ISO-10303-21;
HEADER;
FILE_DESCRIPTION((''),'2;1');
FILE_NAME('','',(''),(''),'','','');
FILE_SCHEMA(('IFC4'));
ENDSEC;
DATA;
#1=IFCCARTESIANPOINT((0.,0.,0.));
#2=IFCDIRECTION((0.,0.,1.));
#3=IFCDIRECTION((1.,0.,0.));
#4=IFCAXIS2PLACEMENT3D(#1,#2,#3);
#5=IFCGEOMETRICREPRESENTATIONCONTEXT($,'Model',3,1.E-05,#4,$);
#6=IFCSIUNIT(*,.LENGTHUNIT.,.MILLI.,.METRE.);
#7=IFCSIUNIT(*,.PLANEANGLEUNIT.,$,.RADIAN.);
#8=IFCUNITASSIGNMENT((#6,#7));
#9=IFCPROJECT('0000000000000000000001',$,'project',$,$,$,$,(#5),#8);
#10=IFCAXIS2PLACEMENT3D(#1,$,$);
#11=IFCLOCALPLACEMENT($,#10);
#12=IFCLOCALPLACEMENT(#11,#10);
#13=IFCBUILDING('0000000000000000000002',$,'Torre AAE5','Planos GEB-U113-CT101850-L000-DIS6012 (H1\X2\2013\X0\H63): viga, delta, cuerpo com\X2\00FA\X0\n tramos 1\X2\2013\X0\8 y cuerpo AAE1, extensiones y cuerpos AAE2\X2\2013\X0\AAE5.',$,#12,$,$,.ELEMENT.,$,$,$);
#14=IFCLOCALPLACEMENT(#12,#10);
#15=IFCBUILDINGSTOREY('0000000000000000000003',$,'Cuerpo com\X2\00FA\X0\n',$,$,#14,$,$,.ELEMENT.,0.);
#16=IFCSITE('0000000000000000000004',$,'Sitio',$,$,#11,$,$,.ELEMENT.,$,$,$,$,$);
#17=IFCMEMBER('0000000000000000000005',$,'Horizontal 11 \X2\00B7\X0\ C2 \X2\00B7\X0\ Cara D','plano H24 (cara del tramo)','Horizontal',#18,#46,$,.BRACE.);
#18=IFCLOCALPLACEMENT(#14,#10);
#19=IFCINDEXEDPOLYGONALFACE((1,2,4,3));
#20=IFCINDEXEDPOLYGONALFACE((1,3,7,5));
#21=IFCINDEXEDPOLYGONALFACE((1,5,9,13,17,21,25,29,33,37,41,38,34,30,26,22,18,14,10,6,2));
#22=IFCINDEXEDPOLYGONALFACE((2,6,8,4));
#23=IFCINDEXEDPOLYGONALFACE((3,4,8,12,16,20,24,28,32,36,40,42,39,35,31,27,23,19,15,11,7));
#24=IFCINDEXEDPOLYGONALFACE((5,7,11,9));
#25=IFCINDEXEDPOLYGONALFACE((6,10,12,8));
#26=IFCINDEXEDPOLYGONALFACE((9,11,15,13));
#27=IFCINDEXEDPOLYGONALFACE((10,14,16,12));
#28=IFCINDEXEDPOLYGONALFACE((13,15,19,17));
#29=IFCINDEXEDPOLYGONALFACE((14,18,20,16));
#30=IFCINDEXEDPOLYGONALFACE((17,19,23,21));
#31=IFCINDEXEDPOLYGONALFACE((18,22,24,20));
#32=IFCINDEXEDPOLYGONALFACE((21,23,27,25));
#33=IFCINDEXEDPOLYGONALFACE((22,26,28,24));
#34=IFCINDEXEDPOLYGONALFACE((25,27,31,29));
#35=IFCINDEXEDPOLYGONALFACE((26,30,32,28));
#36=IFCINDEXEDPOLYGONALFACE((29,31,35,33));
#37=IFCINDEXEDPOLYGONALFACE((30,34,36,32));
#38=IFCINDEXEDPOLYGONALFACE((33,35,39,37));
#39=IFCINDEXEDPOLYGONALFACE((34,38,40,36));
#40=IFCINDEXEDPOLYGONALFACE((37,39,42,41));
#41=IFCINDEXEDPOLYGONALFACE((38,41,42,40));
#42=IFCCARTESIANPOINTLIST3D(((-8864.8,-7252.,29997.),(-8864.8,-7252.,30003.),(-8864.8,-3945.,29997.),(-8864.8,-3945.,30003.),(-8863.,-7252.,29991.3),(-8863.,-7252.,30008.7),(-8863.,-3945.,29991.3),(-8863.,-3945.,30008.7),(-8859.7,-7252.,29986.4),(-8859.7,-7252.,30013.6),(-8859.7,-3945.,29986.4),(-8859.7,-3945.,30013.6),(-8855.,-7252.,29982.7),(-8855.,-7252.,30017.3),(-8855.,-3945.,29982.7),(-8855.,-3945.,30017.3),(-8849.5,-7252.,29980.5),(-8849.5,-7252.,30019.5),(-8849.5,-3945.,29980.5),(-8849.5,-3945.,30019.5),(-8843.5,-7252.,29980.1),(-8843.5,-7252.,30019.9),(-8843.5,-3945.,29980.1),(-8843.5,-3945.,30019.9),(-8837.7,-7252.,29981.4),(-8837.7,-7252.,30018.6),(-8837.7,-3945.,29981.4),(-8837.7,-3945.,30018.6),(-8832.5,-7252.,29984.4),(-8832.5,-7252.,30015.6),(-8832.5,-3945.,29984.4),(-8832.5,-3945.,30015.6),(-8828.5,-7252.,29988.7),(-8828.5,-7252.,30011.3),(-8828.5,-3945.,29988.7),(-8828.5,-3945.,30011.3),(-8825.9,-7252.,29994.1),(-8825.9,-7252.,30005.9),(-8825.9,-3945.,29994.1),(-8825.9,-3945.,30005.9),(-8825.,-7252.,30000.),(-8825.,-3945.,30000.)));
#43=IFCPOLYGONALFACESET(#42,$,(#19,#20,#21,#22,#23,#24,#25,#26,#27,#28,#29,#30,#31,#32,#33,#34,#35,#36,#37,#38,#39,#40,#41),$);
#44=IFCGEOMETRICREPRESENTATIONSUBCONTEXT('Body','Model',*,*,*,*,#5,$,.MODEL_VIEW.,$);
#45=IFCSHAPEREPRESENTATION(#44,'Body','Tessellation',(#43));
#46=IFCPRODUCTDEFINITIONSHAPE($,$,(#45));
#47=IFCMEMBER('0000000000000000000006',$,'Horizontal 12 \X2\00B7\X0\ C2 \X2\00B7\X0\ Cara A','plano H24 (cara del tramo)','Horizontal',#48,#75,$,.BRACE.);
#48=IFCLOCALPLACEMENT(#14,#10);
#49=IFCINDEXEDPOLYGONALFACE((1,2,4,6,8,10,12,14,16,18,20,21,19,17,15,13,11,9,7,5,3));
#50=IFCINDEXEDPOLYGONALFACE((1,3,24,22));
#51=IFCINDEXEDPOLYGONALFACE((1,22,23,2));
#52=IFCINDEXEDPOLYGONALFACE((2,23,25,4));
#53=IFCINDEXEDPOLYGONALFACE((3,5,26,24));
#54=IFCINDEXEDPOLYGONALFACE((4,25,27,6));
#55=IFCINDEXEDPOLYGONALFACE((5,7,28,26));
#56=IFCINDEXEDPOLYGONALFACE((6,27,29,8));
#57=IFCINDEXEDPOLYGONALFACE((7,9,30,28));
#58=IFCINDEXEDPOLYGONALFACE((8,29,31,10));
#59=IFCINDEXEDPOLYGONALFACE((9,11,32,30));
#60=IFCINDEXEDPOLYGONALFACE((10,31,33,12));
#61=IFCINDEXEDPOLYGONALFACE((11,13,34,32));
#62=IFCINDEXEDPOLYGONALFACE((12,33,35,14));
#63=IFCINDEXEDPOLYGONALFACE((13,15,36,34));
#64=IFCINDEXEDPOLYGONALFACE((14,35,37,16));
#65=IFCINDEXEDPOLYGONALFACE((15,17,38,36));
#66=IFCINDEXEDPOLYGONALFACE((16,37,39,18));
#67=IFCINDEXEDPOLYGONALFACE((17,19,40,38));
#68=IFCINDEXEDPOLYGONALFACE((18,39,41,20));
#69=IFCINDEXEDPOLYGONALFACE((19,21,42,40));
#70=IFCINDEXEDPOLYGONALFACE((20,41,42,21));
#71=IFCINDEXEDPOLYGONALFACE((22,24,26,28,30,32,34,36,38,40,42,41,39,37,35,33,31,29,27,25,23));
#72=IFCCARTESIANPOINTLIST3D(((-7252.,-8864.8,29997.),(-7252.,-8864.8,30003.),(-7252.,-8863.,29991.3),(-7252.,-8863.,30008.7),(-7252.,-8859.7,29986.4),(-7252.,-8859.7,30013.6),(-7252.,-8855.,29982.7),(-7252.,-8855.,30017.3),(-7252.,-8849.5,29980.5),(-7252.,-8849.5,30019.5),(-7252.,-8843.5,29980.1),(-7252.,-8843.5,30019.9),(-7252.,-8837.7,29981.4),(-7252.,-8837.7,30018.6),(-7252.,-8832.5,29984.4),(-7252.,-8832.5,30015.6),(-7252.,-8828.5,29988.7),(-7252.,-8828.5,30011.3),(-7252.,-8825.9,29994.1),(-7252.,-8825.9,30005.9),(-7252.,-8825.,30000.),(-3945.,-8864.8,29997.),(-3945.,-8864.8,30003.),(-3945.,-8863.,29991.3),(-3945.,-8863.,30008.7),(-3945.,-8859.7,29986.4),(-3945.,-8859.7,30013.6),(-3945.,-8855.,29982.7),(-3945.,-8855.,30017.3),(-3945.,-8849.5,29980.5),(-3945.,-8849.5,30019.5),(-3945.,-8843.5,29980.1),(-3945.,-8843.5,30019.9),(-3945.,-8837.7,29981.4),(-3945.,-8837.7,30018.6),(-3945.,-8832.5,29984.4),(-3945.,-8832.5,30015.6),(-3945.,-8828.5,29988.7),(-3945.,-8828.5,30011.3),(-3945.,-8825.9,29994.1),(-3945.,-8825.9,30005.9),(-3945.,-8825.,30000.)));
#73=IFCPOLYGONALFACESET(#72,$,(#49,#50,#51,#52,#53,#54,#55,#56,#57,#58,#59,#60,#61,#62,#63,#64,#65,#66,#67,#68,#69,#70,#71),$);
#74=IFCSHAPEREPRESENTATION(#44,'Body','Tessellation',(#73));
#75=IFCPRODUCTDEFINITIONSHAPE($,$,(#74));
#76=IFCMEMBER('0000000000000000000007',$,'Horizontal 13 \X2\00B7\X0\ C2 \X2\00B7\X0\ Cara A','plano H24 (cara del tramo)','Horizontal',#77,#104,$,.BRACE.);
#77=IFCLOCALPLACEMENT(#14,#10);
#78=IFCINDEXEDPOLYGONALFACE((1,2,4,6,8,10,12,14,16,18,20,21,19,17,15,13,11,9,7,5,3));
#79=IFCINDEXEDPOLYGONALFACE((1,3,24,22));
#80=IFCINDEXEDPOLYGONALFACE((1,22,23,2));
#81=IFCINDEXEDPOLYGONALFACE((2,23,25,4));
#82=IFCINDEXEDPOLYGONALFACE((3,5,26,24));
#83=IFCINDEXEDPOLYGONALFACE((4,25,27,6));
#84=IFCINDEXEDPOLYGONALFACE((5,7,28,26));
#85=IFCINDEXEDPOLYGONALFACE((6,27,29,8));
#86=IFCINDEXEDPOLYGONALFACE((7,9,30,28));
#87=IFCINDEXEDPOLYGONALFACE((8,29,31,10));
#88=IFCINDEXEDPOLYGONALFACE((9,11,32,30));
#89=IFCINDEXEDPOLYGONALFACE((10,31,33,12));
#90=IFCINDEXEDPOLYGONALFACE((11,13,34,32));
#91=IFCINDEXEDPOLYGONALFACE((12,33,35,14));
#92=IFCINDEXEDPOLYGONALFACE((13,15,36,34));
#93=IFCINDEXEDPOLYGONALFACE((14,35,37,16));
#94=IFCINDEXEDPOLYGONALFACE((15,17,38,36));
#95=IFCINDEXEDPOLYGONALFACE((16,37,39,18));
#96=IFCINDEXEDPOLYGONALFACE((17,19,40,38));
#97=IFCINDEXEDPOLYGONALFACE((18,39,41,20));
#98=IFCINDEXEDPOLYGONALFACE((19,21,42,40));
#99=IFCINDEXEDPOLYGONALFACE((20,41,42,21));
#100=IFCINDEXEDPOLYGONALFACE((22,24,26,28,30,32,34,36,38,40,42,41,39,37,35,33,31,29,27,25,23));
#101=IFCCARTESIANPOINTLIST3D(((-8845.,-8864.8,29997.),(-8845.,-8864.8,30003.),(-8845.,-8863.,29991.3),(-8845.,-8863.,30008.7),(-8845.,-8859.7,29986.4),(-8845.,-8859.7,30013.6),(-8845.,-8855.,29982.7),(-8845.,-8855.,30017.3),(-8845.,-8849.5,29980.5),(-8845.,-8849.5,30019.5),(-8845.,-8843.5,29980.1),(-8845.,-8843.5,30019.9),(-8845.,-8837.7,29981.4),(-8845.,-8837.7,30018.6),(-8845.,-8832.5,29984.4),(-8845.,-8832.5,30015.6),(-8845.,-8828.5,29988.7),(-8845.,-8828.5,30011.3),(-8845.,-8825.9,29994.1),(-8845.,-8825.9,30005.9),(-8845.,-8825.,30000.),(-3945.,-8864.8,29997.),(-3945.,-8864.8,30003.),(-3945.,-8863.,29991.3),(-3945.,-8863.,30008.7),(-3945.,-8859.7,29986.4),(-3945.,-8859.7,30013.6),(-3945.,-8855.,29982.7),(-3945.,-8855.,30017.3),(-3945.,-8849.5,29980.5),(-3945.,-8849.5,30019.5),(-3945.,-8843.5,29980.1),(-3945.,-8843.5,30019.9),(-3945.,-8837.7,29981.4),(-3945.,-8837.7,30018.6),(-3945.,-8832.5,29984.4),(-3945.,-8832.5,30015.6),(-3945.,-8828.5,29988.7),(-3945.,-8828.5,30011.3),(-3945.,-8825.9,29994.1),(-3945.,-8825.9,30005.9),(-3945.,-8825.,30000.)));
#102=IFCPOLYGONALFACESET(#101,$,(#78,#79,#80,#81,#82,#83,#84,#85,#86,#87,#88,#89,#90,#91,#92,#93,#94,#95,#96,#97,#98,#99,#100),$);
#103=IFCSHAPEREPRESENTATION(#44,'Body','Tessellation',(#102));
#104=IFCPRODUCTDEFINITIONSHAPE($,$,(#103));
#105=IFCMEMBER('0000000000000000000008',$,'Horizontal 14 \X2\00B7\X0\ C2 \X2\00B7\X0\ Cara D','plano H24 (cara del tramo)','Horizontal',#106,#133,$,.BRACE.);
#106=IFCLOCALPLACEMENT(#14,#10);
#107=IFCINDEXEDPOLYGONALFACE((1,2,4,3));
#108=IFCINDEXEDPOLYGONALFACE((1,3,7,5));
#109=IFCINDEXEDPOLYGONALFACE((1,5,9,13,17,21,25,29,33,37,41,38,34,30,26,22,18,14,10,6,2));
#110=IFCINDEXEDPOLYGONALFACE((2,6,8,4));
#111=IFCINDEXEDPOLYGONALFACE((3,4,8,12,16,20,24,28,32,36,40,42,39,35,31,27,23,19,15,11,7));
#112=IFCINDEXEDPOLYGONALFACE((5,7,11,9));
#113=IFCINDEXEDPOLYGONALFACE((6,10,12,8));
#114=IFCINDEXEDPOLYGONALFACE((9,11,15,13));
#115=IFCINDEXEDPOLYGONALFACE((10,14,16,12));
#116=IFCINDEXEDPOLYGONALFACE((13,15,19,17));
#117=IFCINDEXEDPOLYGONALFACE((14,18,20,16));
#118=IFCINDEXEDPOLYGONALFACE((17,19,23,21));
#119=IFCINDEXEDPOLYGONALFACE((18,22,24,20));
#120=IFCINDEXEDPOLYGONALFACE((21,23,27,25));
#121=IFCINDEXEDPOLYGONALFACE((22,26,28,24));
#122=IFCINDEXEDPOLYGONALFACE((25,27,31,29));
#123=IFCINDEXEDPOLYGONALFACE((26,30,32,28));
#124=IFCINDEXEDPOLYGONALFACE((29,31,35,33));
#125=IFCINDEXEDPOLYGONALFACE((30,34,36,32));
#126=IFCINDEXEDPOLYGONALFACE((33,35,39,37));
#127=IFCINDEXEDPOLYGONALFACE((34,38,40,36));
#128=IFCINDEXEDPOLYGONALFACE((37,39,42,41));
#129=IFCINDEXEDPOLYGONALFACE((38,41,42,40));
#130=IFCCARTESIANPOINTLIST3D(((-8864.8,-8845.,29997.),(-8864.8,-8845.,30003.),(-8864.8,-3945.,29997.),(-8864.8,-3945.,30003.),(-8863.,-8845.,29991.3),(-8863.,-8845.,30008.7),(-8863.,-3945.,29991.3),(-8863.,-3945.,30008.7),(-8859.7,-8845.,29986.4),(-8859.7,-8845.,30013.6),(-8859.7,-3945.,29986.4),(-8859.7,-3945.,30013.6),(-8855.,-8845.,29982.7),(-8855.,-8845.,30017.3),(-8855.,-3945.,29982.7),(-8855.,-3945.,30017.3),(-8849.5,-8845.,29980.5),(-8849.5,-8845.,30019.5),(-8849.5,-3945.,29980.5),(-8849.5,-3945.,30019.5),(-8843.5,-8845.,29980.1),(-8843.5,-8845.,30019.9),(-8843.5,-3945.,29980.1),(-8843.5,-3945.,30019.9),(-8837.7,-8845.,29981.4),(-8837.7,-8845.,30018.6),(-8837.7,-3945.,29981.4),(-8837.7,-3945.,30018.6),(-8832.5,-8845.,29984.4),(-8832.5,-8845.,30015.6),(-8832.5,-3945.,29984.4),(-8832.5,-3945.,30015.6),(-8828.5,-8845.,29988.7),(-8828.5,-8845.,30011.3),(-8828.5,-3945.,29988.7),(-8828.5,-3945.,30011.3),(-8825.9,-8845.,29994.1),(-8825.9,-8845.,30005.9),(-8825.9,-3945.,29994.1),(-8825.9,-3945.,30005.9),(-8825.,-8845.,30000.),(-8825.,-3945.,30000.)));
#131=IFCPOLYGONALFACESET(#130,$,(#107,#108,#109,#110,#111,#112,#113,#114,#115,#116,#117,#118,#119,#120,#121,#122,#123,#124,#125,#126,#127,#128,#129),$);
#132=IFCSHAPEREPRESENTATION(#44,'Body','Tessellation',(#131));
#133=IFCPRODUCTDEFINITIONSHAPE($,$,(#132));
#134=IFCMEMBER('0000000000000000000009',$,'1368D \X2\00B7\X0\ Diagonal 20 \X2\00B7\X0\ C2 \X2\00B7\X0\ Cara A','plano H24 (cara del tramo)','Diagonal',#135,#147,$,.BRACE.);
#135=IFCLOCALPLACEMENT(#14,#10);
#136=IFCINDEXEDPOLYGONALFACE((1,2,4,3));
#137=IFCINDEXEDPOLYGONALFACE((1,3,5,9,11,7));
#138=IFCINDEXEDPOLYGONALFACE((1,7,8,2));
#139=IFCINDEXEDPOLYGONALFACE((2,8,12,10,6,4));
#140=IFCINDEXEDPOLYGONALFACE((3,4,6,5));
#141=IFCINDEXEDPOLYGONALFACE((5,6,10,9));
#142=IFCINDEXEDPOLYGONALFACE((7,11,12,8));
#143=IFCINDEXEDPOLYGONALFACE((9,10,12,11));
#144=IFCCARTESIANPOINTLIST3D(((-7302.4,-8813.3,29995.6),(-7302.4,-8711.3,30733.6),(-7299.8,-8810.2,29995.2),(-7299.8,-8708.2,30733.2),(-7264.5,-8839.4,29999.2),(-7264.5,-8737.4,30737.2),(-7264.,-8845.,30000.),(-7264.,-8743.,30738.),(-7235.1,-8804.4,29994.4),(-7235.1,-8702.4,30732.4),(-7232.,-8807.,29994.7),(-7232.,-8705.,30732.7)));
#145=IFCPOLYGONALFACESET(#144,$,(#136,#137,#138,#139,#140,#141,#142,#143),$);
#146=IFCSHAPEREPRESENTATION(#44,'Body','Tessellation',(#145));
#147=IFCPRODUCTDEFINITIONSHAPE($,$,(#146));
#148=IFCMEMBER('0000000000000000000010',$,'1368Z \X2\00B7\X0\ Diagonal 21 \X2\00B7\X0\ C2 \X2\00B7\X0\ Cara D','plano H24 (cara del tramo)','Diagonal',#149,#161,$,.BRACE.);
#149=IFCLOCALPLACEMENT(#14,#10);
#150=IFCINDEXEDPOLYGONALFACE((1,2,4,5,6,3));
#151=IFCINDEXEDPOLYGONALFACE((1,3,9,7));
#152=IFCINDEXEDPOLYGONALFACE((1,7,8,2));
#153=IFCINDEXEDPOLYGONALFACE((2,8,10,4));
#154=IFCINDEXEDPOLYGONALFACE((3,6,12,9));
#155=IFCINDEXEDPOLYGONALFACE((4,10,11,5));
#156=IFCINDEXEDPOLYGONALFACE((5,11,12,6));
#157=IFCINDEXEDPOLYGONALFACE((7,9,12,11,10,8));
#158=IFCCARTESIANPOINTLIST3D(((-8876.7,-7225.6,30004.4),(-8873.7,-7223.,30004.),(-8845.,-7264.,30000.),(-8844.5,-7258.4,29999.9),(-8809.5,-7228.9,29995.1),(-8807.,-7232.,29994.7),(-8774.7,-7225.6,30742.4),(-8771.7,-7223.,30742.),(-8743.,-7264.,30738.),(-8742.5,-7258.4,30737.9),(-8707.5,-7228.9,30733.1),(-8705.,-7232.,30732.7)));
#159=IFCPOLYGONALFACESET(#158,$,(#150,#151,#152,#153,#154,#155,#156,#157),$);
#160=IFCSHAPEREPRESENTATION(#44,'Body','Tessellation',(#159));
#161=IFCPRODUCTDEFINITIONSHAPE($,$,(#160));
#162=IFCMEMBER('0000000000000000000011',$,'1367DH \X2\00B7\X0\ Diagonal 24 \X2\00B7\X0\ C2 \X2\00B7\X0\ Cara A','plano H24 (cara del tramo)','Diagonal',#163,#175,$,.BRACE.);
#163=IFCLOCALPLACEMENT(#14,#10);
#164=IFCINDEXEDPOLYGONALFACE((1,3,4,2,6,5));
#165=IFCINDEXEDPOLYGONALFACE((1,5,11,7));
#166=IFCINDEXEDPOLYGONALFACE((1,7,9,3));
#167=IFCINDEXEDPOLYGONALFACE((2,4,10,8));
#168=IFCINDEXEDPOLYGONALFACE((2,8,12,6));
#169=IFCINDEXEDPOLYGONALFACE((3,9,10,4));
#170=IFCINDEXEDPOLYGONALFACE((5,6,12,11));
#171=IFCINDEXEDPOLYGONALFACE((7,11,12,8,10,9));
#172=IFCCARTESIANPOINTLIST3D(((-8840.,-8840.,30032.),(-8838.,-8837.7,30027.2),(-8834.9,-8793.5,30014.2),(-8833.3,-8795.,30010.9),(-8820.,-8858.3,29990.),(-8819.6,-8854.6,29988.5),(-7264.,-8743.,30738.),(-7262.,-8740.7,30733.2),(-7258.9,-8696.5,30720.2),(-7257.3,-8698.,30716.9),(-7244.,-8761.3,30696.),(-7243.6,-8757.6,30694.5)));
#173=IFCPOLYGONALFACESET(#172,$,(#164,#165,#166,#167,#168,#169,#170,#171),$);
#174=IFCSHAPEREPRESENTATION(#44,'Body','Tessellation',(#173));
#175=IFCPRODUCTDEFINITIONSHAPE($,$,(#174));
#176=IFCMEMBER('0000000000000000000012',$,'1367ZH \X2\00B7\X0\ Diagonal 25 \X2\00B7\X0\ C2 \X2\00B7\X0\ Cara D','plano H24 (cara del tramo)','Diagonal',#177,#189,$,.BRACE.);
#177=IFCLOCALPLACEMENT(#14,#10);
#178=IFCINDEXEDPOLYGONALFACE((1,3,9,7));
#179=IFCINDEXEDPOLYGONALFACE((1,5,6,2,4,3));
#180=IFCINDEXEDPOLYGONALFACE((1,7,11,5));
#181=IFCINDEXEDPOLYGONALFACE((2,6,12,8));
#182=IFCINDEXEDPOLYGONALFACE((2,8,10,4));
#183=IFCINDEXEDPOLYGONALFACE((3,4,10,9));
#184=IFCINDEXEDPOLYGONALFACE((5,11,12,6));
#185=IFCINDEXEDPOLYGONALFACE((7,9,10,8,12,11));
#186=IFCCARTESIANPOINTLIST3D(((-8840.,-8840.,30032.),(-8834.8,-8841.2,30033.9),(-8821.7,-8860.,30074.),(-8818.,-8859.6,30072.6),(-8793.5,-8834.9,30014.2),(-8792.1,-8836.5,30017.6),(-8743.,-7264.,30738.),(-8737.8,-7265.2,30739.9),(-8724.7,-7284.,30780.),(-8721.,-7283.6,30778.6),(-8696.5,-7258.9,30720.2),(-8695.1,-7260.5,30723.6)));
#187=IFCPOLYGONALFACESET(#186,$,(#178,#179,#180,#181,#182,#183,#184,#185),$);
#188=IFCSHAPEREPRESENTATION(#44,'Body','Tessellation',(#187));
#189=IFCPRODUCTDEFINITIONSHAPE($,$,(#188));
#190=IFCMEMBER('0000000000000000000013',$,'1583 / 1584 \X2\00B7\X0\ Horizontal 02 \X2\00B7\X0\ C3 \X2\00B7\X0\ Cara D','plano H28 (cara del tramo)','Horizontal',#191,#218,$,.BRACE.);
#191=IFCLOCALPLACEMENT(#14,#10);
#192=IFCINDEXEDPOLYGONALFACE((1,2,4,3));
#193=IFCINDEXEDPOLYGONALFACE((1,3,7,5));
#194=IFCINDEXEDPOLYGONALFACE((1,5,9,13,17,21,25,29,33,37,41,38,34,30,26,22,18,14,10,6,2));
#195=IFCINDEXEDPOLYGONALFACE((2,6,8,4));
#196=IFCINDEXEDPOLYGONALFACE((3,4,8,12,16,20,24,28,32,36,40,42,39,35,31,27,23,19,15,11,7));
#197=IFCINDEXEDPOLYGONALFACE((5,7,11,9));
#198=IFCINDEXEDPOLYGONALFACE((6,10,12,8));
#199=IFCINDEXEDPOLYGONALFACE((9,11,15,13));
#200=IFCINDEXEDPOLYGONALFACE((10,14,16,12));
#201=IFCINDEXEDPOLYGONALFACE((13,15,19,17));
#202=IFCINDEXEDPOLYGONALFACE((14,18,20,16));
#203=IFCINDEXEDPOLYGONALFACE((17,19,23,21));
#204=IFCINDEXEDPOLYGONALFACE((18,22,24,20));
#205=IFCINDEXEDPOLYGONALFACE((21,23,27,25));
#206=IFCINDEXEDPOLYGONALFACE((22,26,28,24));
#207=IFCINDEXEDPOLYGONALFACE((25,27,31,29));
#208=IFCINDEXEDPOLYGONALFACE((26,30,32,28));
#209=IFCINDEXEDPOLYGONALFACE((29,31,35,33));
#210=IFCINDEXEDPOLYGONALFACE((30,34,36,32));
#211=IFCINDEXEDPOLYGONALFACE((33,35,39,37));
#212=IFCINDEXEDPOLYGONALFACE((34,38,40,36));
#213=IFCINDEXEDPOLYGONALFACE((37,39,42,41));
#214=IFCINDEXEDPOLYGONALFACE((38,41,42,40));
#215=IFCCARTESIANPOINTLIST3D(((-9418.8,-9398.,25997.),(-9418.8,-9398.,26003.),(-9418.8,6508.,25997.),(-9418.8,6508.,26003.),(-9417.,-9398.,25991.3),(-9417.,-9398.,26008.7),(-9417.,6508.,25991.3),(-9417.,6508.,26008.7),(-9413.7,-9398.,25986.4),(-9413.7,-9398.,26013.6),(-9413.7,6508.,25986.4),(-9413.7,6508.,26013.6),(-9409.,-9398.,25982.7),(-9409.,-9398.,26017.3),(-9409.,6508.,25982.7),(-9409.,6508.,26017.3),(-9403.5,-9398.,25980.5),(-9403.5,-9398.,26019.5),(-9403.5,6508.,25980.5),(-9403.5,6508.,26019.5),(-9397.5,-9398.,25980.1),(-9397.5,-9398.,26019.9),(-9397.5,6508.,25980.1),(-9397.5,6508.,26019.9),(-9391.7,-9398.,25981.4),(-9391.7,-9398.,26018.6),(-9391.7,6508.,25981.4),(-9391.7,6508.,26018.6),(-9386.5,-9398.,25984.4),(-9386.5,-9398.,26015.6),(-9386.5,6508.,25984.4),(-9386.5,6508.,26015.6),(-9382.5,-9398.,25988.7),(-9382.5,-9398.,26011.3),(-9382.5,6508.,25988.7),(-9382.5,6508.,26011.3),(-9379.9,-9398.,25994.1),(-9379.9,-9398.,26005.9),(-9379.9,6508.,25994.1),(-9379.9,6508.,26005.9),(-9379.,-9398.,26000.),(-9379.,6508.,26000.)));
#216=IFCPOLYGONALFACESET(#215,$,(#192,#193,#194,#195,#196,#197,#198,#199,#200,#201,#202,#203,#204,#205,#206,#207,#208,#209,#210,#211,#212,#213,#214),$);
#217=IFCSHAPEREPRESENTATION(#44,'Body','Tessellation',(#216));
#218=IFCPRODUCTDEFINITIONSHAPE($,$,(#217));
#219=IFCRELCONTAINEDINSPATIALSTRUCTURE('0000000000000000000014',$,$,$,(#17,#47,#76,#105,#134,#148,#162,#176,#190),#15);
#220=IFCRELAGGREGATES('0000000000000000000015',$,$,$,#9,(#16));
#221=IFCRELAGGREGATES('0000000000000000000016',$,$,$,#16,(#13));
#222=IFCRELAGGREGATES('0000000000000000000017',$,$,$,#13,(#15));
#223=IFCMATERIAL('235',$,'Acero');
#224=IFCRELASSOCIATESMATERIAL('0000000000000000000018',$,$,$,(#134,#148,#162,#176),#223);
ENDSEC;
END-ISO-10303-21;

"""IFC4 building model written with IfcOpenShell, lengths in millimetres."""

from ifc_helpers import new_model, si_unit, frame, frame_2d, origin, origin_with_axes, place, context, subcontext, project, spatial, circle, l_section, extrude, material, element, save


model = new_model("IFC4")

# Units and contexts
model_context = context("Model", 3, precision=1e-05, world=origin_with_axes())
body_context = subcontext(model_context, "Body", "Model", "MODEL_VIEW")
ifc_project = project(units=[si_unit("LENGTHUNIT", "METRE", prefix="MILLI"), si_unit("PLANEANGLEUNIT", "RADIAN")], contexts=[model_context])

# Site, building, storey
site_placement = place(None, origin())
site = spatial("IfcSite", under=ifc_project, at=site_placement, Name="Sitio", CompositionType="ELEMENT")
building_placement = place(site_placement, origin())
building = spatial("IfcBuilding", under=site, at=building_placement, Name="Torre AAE5", Description="Planos GEB-U113-CT101850-L000-DIS6012 (H1–H63): viga, delta, cuerpo común tramos 1–8 y cuerpo AAE1, extensiones y cuerpos AAE2–AAE5.", CompositionType="ELEMENT")
storey_placement = place(building_placement, origin())
storey = spatial("IfcBuildingStorey", under=building, at=storey_placement, Name="Cuerpo común", CompositionType="ELEMENT", Elevation=0.0)

# Members
ifc_material_1 = material(Name="235", Category="Acero")
for number, where, z_axis, x_axis, name in (
    (1, (-8845.0, -7252.0, 30000.0), (0.0, 1.0, 0.0), (1.0, 0.0, 0.0), "Horizontal 11 · C2 · Cara D"),
    (2, (-7252.0, -8845.0, 30000.0), (1.0, 0.0, 0.0), (0.0, 1.0, 0.0), "Horizontal 12 · C2 · Cara A"),
):
    element("IfcMember", number, at=place(storey_placement, frame(where, z_axis=z_axis, x_axis=x_axis)), inside=storey, Name=name, Description="plano H24 (cara del tramo)", ObjectType="Horizontal", PredefinedType="BRACE", context=body_context, shape_type="SweptSolid", body=[
        extrude(circle(Radius=20.0), None, (0.0, 0.0, 1.0), 3307.0),
    ])
for number, where, z_axis, x_axis, name in (
    (3, (-8845.0, -8845.0, 30000.0), (1.0, 0.0, 0.0), (0.0, 1.0, 0.0), "Horizontal 13 · C2 · Cara A"),
    (4, (-8845.0, -8845.0, 30000.0), (0.0, 1.0, 0.0), (1.0, 0.0, 0.0), "Horizontal 14 · C2 · Cara D"),
):
    element("IfcMember", number, at=place(storey_placement, frame(where, z_axis=z_axis, x_axis=x_axis)), inside=storey, Name=name, Description="plano H24 (cara del tramo)", ObjectType="Horizontal", PredefinedType="BRACE", context=body_context, shape_type="SweptSolid", body=[
        extrude(circle(Radius=20.0), None, (0.0, 0.0, 1.0), 4900.0),
    ])
for number, where, z_axis, x_axis, name in (
    (5, (-7264.0, -8845.0, 30000.0), (0.0, 0.13691, 0.990584), (0.640428, 0.760787, -0.105149), "1368D · Diagonal 20 · C2 · Cara A"),
    (6, (-8845.0, -7264.0, 30000.0), (0.13691, 0.0, 0.990584), (0.760787, 0.640428, -0.105149), "1368Z · Diagonal 21 · C2 · Cara D"),
):
    element("IfcMember", number, at=place(storey_placement, frame(where, z_axis=z_axis, x_axis=x_axis)), inside=storey, material=ifc_material_1, Name=name, Description="plano H24 (cara del tramo)", ObjectType="Diagonal", PredefinedType="BRACE", context=body_context, shape_type="SweptSolid", body=[
        extrude(l_section(Depth=50.0, Width=50.0, Thickness=4.0, at=frame_2d((25.0, 25.0))), None, (0.0, 0.0, 1.0), 745.0),
    ])
for number, where, z_axis, x_axis, name in (
    (7, (-7264.0, -8743.0, 30738.0), (-0.911177, -0.056081, -0.40818), (0.102073, 0.929083, -0.355507), "1367DH · Diagonal 24 · C2 · Cara A"),
    (8, (-8743.0, -7264.0, 30738.0), (-0.056081, -0.911177, -0.40818), (0.929083, 0.102073, -0.355507), "1367ZH · Diagonal 25 · C2 · Cara D"),
):
    element("IfcMember", number, at=place(storey_placement, frame(where, z_axis=z_axis, x_axis=x_axis)), inside=storey, material=ifc_material_1, Name=name, Description="plano H24 (cara del tramo)", ObjectType="Diagonal", PredefinedType="BRACE", context=body_context, shape_type="SweptSolid", body=[
        extrude(l_section(Depth=50.0, Width=50.0, Thickness=4.0, at=frame_2d((25.0, 25.0))), None, (0.0, 0.0, 1.0), 1729.6),
    ])
member_1_placement = place(storey_placement, frame((-9399.0, -9398.0, 26000.0), z_axis=(0.0, 1.0, 0.0), x_axis=(1.0, 0.0, 0.0)))
element("IfcMember", 9, at=member_1_placement, inside=storey, Name="1583 / 1584 · Horizontal 02 · C3 · Cara D", Description="plano H28 (cara del tramo)", ObjectType="Horizontal", PredefinedType="BRACE", context=body_context, shape_type="SweptSolid", body=[
    extrude(circle(Radius=20.0), None, (0.0, 0.0, 1.0), 15906.0),
])

save(model, "model.ifc")
